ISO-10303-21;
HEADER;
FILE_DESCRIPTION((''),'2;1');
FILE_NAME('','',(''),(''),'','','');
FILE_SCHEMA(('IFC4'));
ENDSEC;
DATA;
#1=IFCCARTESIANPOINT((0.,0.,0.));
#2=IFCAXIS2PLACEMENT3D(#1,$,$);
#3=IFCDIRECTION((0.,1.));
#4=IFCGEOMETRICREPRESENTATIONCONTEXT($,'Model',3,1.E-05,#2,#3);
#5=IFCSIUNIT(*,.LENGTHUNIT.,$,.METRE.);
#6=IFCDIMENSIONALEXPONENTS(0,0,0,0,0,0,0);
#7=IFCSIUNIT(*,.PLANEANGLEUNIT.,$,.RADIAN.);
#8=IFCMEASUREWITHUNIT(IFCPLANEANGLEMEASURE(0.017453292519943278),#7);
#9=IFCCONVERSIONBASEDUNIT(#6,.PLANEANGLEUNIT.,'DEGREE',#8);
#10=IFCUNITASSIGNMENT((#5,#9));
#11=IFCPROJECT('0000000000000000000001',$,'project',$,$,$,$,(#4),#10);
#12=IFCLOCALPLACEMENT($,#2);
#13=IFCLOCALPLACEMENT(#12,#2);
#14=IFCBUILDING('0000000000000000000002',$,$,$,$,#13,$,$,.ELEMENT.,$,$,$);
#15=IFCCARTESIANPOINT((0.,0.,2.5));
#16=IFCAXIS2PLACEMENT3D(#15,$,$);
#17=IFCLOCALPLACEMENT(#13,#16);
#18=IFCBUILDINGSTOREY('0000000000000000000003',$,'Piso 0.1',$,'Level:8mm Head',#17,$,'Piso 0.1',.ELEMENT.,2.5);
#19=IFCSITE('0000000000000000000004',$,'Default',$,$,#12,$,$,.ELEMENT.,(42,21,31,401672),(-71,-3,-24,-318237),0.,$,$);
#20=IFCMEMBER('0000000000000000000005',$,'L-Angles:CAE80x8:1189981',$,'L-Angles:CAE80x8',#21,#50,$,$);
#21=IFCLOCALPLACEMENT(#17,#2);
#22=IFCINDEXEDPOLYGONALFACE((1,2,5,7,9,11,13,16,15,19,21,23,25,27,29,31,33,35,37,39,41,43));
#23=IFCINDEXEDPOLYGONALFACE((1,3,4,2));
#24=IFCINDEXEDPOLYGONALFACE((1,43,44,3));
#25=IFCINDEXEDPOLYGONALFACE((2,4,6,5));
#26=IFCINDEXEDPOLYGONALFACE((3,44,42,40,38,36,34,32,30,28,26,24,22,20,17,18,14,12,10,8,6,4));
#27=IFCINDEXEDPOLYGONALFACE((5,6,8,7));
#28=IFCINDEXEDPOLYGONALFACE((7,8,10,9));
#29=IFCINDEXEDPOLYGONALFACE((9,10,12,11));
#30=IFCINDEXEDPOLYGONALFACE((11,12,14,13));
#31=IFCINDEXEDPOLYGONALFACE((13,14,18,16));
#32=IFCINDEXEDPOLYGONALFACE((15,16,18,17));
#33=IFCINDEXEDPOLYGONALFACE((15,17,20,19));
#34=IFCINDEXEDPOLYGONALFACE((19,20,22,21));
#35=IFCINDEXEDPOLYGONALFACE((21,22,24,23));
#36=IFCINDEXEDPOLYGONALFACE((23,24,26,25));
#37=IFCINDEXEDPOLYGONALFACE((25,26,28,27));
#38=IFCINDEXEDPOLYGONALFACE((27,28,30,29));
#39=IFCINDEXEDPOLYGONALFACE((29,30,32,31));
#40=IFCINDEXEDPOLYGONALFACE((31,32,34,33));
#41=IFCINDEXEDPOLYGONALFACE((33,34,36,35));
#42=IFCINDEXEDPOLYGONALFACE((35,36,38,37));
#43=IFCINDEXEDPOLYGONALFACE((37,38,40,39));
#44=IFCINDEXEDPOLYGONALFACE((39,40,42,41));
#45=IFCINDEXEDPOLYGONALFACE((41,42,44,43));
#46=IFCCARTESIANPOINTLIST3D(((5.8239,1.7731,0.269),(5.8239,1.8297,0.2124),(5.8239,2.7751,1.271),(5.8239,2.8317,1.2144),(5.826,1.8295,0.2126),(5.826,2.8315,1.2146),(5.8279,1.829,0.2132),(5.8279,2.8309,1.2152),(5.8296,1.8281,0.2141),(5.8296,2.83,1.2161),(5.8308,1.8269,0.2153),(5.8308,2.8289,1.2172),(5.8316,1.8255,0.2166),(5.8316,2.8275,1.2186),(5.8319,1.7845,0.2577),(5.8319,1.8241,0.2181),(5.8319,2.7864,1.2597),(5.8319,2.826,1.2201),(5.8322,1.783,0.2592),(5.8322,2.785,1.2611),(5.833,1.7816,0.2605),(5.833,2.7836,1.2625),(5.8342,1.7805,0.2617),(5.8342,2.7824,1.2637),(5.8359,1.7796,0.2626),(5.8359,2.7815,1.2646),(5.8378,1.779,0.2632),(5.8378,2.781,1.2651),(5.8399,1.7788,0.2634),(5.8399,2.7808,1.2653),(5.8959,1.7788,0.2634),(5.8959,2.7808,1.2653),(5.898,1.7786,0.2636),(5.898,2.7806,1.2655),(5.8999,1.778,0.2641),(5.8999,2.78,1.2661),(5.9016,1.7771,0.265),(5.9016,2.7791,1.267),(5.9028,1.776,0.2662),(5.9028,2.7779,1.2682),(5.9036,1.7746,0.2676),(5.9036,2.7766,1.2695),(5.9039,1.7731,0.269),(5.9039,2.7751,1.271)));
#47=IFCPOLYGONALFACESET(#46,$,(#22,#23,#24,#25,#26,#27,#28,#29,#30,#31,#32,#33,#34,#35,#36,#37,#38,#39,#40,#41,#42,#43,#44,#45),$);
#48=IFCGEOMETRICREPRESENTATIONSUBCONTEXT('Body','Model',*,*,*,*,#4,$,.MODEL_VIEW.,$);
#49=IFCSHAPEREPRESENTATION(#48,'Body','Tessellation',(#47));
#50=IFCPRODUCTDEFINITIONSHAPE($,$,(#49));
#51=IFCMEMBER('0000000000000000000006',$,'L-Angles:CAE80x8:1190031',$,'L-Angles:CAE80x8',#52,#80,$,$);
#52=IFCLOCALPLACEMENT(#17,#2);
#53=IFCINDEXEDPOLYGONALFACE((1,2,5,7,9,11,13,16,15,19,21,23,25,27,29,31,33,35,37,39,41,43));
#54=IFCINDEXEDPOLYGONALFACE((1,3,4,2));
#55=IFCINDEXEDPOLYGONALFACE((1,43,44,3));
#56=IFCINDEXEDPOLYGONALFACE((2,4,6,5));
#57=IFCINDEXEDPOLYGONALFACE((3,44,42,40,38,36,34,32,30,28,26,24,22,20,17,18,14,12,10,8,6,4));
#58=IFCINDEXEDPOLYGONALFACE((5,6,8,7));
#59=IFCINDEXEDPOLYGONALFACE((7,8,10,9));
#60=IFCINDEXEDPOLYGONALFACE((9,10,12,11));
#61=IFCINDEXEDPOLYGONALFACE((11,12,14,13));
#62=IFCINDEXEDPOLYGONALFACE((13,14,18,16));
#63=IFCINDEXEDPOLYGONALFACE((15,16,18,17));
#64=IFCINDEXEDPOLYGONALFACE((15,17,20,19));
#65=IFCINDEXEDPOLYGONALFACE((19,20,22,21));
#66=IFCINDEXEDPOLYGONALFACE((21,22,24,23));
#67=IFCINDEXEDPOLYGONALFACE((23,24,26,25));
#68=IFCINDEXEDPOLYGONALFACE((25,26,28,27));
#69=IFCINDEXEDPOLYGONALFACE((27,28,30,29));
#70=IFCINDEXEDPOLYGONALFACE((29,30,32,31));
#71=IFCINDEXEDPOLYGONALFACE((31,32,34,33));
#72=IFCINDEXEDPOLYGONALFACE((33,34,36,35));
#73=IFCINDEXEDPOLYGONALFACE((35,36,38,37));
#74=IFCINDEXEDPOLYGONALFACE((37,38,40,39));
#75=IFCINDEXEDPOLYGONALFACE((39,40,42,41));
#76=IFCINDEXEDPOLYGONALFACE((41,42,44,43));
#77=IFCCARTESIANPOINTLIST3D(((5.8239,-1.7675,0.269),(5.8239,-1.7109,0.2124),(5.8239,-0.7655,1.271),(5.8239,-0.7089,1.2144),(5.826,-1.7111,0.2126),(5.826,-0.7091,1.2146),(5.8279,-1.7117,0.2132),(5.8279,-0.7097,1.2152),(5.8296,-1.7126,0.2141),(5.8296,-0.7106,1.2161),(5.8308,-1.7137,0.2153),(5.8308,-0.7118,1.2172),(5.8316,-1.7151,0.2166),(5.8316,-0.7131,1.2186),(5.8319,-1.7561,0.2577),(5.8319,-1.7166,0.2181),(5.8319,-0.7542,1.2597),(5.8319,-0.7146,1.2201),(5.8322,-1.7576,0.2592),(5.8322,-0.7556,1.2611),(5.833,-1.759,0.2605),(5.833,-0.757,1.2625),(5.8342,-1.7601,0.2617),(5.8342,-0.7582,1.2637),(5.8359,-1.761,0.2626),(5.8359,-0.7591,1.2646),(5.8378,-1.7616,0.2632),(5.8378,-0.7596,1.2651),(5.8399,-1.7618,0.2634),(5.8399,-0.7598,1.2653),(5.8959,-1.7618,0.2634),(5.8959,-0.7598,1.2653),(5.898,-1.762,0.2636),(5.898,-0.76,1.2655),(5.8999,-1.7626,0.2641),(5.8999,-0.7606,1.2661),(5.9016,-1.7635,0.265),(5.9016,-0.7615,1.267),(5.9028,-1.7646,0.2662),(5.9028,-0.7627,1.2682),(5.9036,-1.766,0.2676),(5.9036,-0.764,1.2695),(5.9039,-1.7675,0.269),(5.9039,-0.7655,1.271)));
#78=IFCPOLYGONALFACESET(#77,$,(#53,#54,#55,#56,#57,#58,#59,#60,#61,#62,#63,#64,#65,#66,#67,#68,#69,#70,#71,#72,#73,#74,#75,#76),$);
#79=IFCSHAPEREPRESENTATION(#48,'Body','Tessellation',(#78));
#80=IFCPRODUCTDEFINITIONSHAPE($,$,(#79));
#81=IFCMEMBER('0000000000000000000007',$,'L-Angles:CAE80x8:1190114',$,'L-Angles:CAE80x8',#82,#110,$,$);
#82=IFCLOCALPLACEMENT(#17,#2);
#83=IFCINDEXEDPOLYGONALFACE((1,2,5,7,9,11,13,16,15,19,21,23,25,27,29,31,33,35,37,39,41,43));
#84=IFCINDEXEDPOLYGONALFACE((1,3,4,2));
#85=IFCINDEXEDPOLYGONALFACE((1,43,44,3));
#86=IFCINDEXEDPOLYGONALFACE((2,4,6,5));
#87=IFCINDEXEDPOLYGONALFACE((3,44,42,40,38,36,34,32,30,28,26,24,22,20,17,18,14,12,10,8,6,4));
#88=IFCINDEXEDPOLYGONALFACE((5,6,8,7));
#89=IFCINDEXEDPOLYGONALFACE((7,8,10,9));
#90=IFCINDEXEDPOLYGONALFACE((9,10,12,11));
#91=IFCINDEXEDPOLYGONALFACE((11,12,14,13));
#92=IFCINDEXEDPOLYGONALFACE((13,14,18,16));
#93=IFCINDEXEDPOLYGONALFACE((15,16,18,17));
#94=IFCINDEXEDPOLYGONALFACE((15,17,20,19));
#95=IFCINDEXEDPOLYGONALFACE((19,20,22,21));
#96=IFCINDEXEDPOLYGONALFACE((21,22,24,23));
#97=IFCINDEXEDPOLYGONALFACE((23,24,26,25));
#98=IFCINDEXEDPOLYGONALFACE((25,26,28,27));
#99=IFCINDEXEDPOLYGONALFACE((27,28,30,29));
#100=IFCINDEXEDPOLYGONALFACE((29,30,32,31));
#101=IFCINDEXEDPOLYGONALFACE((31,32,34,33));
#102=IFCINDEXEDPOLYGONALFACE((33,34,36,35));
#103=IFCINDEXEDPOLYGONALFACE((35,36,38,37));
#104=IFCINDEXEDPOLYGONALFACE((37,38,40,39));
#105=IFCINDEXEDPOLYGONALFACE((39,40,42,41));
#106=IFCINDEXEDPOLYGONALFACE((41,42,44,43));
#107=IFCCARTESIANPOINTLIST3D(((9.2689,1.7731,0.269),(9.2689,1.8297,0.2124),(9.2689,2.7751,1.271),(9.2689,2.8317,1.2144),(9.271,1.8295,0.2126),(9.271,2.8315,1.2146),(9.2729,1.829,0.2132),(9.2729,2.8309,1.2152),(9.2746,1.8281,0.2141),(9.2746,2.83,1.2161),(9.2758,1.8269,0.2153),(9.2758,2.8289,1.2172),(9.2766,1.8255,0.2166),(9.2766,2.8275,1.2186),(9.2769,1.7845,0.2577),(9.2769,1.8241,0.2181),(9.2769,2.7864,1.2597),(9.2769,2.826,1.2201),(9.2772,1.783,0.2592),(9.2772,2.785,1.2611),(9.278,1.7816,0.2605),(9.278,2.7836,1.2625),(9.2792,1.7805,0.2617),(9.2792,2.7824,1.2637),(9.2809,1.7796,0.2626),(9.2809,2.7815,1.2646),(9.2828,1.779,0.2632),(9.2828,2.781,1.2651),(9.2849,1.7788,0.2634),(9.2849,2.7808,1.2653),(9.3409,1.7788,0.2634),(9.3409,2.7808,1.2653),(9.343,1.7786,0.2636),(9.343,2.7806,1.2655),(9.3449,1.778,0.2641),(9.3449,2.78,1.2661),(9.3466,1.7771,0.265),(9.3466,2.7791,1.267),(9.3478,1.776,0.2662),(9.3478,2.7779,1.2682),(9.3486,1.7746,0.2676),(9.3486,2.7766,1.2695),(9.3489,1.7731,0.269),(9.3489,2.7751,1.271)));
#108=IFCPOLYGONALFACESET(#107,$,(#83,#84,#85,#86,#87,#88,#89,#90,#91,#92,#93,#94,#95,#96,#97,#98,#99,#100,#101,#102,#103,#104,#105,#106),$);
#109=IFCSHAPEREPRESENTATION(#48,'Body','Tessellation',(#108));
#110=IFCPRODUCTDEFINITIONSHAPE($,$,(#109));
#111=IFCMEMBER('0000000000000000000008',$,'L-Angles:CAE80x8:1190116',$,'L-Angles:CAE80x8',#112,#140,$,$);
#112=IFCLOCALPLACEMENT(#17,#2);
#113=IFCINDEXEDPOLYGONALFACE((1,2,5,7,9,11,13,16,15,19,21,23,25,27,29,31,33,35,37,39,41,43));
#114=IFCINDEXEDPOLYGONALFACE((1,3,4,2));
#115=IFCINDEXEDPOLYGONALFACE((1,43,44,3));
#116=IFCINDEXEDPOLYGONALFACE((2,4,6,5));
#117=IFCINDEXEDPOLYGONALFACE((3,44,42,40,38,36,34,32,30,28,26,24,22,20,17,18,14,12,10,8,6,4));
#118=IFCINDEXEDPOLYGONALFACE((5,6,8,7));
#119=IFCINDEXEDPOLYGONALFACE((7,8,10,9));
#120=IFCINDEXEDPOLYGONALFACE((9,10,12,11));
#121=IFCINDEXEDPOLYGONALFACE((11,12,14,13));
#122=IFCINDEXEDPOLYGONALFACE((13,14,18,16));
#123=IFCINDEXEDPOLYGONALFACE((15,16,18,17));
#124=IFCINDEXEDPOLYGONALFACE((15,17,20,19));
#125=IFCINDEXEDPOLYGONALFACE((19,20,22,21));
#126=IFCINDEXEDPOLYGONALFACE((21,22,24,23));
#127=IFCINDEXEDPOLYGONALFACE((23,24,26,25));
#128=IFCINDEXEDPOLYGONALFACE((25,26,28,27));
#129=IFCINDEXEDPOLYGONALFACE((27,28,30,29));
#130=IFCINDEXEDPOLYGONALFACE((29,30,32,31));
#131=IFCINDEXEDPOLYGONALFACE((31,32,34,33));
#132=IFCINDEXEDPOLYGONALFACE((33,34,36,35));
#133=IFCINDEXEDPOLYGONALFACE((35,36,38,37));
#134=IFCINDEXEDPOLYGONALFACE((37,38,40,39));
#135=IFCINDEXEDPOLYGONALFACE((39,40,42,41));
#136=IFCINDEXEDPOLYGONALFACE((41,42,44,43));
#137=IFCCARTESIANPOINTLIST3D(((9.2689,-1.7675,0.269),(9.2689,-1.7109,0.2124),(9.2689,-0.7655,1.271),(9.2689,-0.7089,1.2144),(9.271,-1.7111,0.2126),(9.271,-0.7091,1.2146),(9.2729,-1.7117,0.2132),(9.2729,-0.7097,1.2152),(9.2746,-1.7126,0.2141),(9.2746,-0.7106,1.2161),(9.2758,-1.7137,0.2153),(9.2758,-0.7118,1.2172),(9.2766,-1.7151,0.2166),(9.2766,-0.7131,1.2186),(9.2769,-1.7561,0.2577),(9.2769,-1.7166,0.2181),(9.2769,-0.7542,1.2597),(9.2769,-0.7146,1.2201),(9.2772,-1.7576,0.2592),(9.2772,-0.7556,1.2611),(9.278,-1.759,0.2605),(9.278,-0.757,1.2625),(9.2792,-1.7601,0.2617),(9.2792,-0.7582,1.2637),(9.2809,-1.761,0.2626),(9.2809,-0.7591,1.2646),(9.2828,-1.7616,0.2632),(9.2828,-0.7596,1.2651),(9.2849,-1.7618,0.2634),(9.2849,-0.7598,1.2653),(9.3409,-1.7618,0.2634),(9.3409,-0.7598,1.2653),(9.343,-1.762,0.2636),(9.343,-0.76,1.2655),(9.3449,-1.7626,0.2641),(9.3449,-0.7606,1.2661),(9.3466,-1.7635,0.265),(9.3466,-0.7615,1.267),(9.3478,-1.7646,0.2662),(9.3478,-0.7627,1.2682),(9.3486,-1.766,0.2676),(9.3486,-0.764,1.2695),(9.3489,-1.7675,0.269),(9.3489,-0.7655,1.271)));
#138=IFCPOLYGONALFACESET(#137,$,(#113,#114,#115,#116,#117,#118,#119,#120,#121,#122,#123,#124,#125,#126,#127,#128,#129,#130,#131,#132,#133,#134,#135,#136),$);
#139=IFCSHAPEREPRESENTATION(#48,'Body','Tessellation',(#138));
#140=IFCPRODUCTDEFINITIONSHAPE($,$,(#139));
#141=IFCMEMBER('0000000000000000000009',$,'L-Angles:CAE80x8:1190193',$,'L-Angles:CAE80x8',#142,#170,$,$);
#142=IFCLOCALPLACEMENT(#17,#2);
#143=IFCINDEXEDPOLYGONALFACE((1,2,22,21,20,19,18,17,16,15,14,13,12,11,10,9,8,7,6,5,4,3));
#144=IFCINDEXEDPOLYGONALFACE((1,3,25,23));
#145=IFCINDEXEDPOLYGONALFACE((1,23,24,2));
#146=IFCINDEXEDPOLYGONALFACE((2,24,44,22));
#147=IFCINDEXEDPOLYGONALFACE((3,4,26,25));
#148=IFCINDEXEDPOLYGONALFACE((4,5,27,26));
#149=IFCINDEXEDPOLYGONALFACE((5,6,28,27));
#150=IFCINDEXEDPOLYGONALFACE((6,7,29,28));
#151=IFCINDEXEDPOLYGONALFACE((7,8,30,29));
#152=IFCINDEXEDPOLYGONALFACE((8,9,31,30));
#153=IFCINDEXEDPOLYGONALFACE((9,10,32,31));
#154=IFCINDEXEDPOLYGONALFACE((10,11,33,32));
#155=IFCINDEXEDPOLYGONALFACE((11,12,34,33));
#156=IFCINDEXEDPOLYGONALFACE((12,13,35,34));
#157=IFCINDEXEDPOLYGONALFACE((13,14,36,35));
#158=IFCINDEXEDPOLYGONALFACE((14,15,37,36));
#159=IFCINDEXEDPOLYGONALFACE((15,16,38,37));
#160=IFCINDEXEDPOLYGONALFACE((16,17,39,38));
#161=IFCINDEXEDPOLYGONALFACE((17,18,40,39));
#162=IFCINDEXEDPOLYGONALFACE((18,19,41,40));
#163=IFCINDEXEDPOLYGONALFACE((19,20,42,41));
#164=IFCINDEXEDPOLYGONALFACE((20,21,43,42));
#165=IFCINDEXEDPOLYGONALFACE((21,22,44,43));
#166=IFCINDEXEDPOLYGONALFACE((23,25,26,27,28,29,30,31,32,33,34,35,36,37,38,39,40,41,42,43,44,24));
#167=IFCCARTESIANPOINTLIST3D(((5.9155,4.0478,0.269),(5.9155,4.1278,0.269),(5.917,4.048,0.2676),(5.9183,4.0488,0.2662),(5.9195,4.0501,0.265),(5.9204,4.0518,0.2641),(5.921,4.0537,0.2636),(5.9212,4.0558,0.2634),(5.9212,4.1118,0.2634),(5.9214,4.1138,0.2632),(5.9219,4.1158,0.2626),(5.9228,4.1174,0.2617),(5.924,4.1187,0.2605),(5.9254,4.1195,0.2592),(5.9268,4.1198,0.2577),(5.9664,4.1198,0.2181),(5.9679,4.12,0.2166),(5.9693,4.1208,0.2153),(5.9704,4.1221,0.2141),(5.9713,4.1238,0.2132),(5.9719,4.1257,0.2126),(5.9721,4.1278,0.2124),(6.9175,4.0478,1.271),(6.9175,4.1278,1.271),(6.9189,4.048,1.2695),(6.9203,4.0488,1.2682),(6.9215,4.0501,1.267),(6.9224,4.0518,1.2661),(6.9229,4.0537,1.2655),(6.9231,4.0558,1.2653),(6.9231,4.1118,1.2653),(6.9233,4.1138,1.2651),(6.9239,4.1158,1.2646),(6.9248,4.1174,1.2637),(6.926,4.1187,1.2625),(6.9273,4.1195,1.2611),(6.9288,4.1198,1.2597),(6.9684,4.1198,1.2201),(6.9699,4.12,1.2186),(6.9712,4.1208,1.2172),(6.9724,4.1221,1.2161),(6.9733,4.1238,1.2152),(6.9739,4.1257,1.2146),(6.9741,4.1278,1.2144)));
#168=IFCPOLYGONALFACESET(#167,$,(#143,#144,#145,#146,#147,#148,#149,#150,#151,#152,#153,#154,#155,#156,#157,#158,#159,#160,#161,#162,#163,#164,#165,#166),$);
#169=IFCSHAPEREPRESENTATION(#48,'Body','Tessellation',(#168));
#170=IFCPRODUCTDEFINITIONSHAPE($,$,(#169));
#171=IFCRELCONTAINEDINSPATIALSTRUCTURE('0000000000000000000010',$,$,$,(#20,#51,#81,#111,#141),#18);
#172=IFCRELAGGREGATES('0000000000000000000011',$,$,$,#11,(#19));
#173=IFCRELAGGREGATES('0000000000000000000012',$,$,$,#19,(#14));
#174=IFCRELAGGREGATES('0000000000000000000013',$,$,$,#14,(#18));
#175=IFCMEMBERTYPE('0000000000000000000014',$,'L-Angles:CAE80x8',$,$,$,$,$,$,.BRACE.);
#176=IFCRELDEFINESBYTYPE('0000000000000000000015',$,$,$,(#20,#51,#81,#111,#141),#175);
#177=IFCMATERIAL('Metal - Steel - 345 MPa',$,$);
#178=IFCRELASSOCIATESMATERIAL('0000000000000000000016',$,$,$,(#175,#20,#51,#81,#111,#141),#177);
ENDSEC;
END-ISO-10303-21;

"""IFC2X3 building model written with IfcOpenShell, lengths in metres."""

from ifc_helpers import new_model, entity, si_unit, converted_unit, direction, frame, frame_2d, origin, place, context, subcontext, project, spatial, polyline, circle_curve, parameter, trimmed, segment, composite_curve, outline, extrude, source, transform, mapped, material, type_object, type_shapes, element, save


model = new_model("IFC2X3")

# Units and contexts
model_context = context("Model", 3, precision=1e-05, world=origin(), true_north=direction((0.0, 1.0)))
body_context = subcontext(model_context, "Body", "Model", "MODEL_VIEW")
ifc_project = project(units=[si_unit("LENGTHUNIT", "METRE"), converted_unit("PLANEANGLEUNIT", "DEGREE", entity("IfcPlaneAngleMeasure", 0.017453292519943278), si_unit("PLANEANGLEUNIT", "RADIAN"), dimensions=[0, 0, 0, 0, 0, 0, 0])], contexts=[model_context])

# Site, building, storey
site_placement = place(None, origin())
site = spatial("IfcSite", under=ifc_project, at=site_placement, Name="Default", CompositionType="ELEMENT", RefLatitude=(42, 21, 31, 401672), RefLongitude=(-71, -3, -24, -318237), RefElevation=0.0)
building_placement = place(site_placement, origin())
building = spatial("IfcBuilding", under=site, at=building_placement, CompositionType="ELEMENT")
storey_placement = place(building_placement, frame((0.0, 0.0, 2.5)))
storey = spatial("IfcBuildingStorey", under=building, at=storey_placement, Name="Piso 0.1", ObjectType="Level:8mm Head", LongName="Piso 0.1", CompositionType="ELEMENT", Elevation=2.5)

# Members
ifc_material = material(Name="Metal - Steel - 345 MPa")
member_type_1 = type_object("IfcMemberType", Name="L-Angles:CAE80x8", PredefinedType="BRACE", material=ifc_material)
shared_shape_1 = source(origin(), body_context, "Body", "SweptSolid", [
    extrude(outline(composite_curve([segment(polyline([(-0.0263, -0.0263), (0.0537, -0.0263)]), True, "CONTINUOUS"), segment(trimmed(circle_curve(frame_2d((0.0457, -0.0263), x_axis=(1.0, 0.0)), 0.008), [parameter(0.0)], [parameter(90.0)], True, "PARAMETER"), True, "CONTINUOUS"), segment(polyline([(0.0457, -0.0183), (-0.0103, -0.0183)]), True, "CONTINUOUS"), segment(trimmed(circle_curve(frame_2d((-0.0103, -0.0103), x_axis=(1.0, 0.0)), 0.008), [parameter(180.0)], [parameter(270.0)], True, "PARAMETER"), False, "CONTINUOUS"), segment(polyline([(-0.0183, -0.0103), (-0.0183, 0.0457)]), True, "CONTINUOUS"), segment(trimmed(circle_curve(frame_2d((-0.0263, 0.0457), x_axis=(1.0, 0.0)), 0.008), [parameter(0.0)], [parameter(90.0)], True, "PARAMETER"), True, "CONTINUOUS"), segment(polyline([(-0.0263, 0.0537), (-0.0263, -0.0263)]), True, "CONTINUOUS")], self_intersect=False)), frame((-0.7085, -0.0037, -0.0037), z_axis=(1.0, 0.0, 0.0), x_axis=(0.0, -1.0, 0.0)), (0.0, 0.0, 1.0), 1.417),
])
type_shapes(member_type_1, [shared_shape_1])
for number, where, z_axis, x_axis, name in (
    (1, (5.8465, 2.2901, 0.754), (0.0, -0.707107, 0.707107), (0.0, 0.707107, 0.707107), "L-Angles:CAE80x8:1189981"),
    (2, (5.8465, -1.2505, 0.754), (0.0, -0.707107, 0.707107), (0.0, 0.707107, 0.707107), "L-Angles:CAE80x8:1190031"),
    (3, (9.2915, 2.2901, 0.754), (0.0, -0.707107, 0.707107), (0.0, 0.707107, 0.707107), "L-Angles:CAE80x8:1190114"),
    (4, (9.2915, -1.2505, 0.754), (0.0, -0.707107, 0.707107), (0.0, 0.707107, 0.707107), "L-Angles:CAE80x8:1190116"),
    (5, (6.4325, 4.1052, 0.754), (-0.707107, 0.0, 0.707107), (0.707107, 0.0, 0.707107), "L-Angles:CAE80x8:1190193"),
):
    element("IfcMember", number, at=place(storey_placement, frame(where, z_axis=z_axis, x_axis=x_axis)), inside=storey, type_object=member_type_1, material=ifc_material, Name=name, ObjectType="L-Angles:CAE80x8", context=body_context, shape_type="MappedRepresentation", body=[
        mapped(shared_shape_1, transform((0.0, 0.0, 0.0), scale=1.0)),
    ])

save(model, "model.ifc")
